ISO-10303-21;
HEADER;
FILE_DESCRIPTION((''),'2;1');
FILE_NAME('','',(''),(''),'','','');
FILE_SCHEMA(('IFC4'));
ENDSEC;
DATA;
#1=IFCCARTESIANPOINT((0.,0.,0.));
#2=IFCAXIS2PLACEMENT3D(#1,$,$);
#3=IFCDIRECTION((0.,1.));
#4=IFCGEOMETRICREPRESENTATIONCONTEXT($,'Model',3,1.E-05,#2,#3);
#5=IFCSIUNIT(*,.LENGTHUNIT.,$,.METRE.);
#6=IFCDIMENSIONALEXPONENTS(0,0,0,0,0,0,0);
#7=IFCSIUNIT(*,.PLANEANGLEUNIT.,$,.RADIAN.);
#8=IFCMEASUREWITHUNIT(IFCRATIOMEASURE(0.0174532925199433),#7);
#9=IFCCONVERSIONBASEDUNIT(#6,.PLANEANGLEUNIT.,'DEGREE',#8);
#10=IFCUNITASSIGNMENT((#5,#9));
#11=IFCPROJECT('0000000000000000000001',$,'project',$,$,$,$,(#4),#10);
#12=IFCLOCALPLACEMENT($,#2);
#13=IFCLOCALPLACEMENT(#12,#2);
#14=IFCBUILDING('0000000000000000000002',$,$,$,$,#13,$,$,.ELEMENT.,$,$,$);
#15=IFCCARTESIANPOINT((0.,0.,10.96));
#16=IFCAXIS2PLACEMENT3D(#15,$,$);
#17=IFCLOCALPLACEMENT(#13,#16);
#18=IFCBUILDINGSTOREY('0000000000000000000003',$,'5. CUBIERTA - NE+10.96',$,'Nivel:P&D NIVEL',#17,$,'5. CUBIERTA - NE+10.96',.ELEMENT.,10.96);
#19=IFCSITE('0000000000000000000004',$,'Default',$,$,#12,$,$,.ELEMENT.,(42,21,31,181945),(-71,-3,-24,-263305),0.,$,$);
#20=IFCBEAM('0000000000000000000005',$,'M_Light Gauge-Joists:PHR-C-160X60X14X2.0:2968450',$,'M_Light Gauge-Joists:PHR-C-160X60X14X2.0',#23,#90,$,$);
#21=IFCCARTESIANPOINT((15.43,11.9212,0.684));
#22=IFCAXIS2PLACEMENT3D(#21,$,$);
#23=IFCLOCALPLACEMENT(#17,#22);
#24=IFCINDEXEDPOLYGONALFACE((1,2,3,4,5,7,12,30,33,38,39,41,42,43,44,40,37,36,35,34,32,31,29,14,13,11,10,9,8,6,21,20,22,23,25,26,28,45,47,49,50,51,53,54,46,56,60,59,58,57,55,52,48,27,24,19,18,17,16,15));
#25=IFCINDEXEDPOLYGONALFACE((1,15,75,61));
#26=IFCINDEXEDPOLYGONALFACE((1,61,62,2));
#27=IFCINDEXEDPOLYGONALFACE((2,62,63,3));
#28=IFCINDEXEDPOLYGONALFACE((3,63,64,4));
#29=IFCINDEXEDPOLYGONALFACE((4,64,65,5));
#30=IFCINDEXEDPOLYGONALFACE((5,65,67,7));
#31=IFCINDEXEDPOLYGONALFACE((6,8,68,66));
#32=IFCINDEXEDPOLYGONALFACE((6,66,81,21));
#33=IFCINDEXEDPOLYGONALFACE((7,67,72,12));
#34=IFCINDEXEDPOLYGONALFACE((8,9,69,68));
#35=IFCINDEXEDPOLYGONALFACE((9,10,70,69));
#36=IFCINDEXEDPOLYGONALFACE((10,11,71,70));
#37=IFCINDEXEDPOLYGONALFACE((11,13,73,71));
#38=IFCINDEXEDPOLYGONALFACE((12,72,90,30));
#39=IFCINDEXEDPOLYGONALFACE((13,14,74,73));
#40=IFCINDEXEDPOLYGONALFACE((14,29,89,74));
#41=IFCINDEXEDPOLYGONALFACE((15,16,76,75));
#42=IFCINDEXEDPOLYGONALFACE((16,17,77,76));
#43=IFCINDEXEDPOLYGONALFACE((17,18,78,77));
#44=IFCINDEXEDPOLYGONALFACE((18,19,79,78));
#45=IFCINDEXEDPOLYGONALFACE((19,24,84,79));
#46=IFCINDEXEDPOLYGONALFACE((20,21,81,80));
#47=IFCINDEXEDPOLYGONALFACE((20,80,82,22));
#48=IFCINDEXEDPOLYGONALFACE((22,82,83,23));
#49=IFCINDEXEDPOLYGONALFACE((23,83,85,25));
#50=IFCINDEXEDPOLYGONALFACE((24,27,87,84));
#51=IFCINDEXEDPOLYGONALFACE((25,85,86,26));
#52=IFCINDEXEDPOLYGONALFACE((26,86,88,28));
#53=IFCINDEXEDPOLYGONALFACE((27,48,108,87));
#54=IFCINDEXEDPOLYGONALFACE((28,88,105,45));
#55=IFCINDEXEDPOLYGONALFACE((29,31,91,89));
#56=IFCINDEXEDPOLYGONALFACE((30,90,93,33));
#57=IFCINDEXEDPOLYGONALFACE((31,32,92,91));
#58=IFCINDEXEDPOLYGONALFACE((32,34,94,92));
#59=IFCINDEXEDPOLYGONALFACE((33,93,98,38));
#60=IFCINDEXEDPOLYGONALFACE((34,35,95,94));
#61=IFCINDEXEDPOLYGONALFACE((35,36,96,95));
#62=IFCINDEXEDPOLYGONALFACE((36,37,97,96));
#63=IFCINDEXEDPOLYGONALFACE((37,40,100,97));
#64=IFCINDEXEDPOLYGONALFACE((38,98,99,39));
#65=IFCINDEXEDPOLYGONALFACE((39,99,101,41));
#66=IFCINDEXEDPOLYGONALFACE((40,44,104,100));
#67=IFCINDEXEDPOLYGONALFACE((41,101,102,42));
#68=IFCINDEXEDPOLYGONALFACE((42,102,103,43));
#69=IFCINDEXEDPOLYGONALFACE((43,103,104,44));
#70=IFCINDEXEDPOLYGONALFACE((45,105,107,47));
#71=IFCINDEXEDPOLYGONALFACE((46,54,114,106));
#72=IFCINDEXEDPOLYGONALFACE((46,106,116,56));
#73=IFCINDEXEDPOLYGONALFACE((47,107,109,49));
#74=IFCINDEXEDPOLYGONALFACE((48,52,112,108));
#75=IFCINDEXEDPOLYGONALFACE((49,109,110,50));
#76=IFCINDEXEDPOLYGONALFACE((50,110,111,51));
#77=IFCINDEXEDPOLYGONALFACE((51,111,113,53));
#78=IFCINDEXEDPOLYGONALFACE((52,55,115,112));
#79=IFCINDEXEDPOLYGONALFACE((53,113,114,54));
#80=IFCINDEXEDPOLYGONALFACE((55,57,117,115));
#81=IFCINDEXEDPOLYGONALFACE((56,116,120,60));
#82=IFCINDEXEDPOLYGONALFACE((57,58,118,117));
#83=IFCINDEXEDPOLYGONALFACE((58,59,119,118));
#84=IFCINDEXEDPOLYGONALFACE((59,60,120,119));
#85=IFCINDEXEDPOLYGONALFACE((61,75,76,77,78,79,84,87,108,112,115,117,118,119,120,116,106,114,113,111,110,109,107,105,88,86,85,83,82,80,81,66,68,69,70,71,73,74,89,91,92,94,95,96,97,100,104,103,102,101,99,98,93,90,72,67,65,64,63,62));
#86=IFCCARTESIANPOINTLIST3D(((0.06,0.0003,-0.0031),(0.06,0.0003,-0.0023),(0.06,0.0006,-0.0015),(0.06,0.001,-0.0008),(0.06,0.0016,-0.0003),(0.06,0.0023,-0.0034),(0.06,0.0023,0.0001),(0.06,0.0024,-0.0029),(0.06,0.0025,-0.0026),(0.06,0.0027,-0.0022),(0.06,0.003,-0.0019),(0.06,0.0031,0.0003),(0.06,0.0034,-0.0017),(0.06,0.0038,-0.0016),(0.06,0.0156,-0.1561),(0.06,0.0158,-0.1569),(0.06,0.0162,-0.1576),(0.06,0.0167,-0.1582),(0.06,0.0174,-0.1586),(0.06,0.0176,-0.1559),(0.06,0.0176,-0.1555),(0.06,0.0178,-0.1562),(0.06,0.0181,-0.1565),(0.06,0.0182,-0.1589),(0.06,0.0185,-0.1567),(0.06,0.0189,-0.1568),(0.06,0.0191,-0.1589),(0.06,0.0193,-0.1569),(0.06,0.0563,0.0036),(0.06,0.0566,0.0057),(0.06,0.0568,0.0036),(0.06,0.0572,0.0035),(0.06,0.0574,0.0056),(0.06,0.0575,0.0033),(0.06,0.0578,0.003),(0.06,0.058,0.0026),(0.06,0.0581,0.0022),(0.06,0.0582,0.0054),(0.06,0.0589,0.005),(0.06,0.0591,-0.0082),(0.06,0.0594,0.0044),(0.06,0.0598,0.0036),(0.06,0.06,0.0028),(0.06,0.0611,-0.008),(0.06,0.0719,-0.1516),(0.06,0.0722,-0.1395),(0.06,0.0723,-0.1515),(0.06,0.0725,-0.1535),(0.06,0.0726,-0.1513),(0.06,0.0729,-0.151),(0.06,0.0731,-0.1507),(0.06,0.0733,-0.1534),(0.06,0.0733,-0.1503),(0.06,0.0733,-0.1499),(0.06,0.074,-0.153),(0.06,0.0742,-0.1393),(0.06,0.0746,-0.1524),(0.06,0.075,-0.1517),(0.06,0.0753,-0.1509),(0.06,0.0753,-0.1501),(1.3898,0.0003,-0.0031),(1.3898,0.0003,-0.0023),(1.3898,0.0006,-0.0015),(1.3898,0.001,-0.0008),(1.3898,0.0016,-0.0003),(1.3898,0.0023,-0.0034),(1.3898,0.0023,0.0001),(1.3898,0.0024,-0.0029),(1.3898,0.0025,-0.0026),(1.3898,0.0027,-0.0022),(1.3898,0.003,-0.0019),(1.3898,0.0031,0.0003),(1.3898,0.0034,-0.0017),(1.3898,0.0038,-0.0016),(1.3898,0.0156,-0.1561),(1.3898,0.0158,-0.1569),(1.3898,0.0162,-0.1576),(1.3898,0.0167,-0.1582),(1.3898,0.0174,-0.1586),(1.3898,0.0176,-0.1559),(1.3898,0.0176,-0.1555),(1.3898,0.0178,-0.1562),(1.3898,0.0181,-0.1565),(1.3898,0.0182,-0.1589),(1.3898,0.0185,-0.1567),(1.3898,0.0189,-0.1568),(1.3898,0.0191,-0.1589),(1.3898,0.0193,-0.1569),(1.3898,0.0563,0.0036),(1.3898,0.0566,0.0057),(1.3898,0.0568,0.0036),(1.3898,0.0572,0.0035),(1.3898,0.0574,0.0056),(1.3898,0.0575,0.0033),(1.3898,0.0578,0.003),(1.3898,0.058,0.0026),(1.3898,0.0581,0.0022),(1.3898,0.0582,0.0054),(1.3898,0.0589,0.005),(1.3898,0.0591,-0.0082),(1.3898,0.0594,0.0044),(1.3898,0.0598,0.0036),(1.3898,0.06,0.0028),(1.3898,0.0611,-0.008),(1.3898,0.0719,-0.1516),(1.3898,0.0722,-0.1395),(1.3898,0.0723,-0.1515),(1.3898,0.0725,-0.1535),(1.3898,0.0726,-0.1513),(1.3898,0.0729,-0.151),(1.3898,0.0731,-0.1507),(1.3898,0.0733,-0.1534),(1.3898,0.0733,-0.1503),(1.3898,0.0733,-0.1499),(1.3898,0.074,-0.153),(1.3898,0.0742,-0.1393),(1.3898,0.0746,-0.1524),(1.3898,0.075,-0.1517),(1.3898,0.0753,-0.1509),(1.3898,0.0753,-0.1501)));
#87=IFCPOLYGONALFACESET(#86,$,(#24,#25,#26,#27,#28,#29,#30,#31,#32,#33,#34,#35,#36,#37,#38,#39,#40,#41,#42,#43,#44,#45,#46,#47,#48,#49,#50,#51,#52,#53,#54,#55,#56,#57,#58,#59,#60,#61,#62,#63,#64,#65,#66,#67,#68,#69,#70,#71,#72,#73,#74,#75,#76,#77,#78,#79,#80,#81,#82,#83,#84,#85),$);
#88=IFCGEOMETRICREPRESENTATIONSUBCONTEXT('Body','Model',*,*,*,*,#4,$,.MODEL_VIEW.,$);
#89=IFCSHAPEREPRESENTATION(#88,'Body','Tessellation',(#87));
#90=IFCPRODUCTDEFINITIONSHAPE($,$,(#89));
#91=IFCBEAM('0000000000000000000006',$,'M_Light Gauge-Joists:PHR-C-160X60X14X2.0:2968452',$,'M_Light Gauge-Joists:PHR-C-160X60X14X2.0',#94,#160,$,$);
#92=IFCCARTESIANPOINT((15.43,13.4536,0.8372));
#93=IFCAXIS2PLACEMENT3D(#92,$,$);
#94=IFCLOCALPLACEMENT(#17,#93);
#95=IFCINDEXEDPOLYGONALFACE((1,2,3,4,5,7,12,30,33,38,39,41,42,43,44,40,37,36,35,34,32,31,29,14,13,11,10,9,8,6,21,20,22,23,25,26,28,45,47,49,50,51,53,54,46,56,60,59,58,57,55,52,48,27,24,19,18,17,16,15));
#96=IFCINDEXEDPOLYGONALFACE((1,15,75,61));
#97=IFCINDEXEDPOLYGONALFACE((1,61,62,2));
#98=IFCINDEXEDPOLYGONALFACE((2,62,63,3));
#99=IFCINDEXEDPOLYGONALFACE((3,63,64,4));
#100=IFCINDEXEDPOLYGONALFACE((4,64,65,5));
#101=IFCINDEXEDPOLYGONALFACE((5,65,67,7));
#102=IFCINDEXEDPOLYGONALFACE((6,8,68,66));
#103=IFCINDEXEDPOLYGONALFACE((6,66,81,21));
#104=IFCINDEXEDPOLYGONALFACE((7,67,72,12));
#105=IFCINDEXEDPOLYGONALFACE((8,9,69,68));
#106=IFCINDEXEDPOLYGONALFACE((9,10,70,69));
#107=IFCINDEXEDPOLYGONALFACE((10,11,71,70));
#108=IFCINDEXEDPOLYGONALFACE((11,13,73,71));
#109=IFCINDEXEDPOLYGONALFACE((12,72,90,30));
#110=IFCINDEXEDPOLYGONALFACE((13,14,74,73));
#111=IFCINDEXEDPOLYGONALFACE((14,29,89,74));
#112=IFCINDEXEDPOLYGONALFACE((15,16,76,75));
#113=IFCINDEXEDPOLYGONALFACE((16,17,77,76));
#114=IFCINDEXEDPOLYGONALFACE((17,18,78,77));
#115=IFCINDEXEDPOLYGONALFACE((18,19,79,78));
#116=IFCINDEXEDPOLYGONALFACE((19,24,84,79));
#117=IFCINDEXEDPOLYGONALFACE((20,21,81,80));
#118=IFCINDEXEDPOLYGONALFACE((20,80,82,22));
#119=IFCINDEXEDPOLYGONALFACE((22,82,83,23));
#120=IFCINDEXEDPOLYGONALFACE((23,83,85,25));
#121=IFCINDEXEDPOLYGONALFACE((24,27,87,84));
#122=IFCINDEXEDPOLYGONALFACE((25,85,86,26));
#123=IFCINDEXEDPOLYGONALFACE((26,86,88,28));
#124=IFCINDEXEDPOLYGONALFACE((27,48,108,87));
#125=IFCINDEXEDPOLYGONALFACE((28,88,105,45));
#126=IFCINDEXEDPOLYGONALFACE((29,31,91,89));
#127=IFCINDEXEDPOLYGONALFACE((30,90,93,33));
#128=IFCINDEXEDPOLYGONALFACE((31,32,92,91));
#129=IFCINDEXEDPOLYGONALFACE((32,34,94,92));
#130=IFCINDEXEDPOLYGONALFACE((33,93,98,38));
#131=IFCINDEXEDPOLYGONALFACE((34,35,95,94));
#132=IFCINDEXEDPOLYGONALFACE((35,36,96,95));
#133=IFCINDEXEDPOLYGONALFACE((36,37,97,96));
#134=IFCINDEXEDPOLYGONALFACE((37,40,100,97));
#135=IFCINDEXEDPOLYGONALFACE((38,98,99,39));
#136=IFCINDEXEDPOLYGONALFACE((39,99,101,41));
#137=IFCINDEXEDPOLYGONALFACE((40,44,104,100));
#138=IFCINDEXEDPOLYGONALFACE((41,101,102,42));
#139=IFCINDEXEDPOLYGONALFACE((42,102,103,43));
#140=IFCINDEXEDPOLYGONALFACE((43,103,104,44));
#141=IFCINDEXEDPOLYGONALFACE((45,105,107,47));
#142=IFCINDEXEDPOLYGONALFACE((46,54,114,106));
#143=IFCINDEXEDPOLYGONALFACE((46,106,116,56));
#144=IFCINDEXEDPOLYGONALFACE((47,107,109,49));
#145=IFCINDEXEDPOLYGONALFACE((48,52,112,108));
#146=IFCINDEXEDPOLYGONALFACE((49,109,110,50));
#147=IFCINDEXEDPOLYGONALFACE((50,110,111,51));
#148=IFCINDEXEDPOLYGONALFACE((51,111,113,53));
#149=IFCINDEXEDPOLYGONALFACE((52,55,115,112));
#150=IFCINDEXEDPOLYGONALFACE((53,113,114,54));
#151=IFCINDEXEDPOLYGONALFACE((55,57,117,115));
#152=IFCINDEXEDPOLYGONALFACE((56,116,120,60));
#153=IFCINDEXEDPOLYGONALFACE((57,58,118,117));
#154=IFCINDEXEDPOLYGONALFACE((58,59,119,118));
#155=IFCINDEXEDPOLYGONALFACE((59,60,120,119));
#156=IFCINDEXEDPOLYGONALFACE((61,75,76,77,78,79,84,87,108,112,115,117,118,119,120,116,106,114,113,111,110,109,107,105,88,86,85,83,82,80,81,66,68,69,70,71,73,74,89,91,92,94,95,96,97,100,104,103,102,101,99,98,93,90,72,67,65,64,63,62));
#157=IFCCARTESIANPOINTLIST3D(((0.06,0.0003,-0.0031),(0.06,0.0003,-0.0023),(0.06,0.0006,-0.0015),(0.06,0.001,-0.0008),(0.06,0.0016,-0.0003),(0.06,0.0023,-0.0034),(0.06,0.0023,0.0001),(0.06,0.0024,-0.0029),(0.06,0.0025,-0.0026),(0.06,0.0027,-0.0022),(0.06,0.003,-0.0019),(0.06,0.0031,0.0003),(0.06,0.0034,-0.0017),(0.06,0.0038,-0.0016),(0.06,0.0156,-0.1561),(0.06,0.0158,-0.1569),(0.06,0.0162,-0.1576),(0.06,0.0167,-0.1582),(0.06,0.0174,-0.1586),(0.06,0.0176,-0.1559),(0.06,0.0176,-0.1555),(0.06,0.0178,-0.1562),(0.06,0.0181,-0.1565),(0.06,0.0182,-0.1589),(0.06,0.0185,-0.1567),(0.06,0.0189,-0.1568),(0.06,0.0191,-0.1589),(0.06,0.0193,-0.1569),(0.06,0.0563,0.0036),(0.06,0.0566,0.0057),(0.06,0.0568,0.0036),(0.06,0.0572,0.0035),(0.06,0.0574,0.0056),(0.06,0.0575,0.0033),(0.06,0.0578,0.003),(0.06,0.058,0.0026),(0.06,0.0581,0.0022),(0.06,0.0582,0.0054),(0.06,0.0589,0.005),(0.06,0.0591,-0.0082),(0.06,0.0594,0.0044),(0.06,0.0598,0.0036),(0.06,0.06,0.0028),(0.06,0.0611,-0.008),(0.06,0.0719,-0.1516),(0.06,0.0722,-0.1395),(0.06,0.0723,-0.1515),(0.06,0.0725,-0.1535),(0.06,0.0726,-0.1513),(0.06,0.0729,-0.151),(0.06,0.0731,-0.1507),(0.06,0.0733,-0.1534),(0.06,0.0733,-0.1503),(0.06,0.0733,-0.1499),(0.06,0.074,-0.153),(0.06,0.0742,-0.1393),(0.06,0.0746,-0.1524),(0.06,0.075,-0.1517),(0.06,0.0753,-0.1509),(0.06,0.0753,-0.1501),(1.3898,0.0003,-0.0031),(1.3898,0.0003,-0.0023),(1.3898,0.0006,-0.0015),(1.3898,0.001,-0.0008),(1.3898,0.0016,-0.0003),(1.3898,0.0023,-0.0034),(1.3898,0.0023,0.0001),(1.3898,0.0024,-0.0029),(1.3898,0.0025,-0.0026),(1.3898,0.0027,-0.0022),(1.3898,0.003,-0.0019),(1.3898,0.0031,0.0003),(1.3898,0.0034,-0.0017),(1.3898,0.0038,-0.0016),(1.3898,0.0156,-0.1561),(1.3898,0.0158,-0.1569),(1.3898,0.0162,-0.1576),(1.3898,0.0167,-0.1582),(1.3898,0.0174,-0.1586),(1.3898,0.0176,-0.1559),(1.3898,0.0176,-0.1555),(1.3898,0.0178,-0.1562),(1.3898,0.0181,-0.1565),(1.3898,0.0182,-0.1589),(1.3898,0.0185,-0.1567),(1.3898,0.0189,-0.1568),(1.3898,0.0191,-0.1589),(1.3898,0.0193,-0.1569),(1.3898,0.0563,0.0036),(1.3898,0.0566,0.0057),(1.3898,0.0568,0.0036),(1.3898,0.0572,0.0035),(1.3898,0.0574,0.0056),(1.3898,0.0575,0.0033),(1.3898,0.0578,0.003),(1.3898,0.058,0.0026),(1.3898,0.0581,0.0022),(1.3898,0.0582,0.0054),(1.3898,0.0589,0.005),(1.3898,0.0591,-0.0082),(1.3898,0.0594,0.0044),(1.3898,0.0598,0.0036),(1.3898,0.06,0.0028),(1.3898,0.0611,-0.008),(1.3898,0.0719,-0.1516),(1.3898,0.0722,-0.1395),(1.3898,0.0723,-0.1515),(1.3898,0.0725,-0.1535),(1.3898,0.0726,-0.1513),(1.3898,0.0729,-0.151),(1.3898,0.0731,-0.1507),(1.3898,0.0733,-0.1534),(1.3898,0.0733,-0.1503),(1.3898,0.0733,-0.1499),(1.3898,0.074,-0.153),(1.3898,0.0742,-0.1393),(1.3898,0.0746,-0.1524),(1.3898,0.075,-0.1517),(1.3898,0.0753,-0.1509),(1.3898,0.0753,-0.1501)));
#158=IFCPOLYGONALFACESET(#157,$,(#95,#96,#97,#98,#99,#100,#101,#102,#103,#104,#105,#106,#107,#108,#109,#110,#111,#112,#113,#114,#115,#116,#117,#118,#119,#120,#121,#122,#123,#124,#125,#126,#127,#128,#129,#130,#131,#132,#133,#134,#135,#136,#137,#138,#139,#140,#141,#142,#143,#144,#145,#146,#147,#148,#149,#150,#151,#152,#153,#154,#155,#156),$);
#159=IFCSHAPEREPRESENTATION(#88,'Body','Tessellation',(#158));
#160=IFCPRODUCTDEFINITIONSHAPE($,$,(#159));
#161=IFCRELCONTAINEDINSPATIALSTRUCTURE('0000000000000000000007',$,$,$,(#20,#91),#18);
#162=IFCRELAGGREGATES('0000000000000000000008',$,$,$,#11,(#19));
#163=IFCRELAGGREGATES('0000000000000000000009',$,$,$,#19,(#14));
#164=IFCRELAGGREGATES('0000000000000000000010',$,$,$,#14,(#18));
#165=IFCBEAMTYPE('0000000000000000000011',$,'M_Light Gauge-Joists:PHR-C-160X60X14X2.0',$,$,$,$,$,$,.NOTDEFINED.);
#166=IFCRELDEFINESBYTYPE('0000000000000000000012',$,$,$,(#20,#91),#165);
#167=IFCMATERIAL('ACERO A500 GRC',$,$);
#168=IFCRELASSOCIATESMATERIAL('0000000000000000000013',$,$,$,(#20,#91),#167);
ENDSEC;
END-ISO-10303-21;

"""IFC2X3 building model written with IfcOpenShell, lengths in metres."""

from ifc_helpers import new_model, entity, si_unit, converted_unit, direction, frame, frame_2d, origin, place, context, subcontext, project, spatial, polyline, circle_curve, parameter, trimmed, segment, composite_curve, outline, extrude, material, type_object, element, save


model = new_model("IFC2X3")

# Units and contexts
model_context = context("Model", 3, precision=1e-05, world=origin(), true_north=direction((0.0, 1.0)))
body_context = subcontext(model_context, "Body", "Model", "MODEL_VIEW")
ifc_project = project(units=[si_unit("LENGTHUNIT", "METRE"), converted_unit("PLANEANGLEUNIT", "DEGREE", entity("IfcRatioMeasure", 0.0174532925199433), si_unit("PLANEANGLEUNIT", "RADIAN"), dimensions=[0, 0, 0, 0, 0, 0, 0])], contexts=[model_context])

# Site, building, storey
site_placement = place(None, origin())
site = spatial("IfcSite", under=ifc_project, at=site_placement, Name="Default", CompositionType="ELEMENT", RefLatitude=(42, 21, 31, 181945), RefLongitude=(-71, -3, -24, -263305), RefElevation=0.0)
building_placement = place(site_placement, origin())
building = spatial("IfcBuilding", under=site, at=building_placement, CompositionType="ELEMENT")
storey_placement = place(building_placement, frame((0.0, 0.0, 10.96)))
storey = spatial("IfcBuildingStorey", under=building, at=storey_placement, Name="5. CUBIERTA - NE+10.96", ObjectType="Nivel:P&D NIVEL", LongName="5. CUBIERTA - NE+10.96", CompositionType="ELEMENT", Elevation=10.96)

# Beams
ifc_material_1 = material(Name="ACERO A500 GRC")
beam_type_1 = type_object("IfcBeamType", Name="M_Light Gauge-Joists:PHR-C-160X60X14X2.0", PredefinedType="NOTDEFINED")
beam_1_placement = place(storey_placement, frame((15.43, 11.9212, 0.684)))
element("IfcBeam", 1, at=beam_1_placement, inside=storey, type_object=beam_type_1, material=ifc_material_1, Name="M_Light Gauge-Joists:PHR-C-160X60X14X2.0:2968450", ObjectType="M_Light Gauge-Joists:PHR-C-160X60X14X2.0", context=body_context, shape_type="SweptSolid", body=[
    extrude(outline(composite_curve([segment(trimmed(circle_curve(frame_2d((-0.0764, -0.0322), x_axis=(-1.0, 0.0)), 0.0016), [parameter(0.0)], [parameter(90.0)], True, "PARAMETER"), False, "CONTINUOUS"), segment(polyline([(-0.078, -0.0322), (-0.078, 0.0206)]), True, "CONTINUOUS"), segment(trimmed(circle_curve(frame_2d((-0.0764, 0.0206), x_axis=(0.0, 1.0)), 0.0016), [parameter(0.0)], [parameter(90.0)], True, "PARAMETER"), False, "CONTINUOUS"), segment(polyline([(-0.0764, 0.0222), (-0.066, 0.0222)]), True, "CONTINUOUS"), segment(polyline([(-0.066, 0.0222), (-0.066, 0.0242)]), True, "CONTINUOUS"), segment(polyline([(-0.066, 0.0242), (-0.0768, 0.0242)]), True, "CONTINUOUS"), segment(trimmed(circle_curve(frame_2d((-0.0768, 0.021), x_axis=(-1.0, 0.0)), 0.0032), [parameter(270.0)], [parameter(0.0)], True, "PARAMETER"), True, "CONTINUOUS"), segment(polyline([(-0.08, 0.021), (-0.08, -0.0326)]), True, "CONTINUOUS"), segment(trimmed(circle_curve(frame_2d((-0.0768, -0.0326), x_axis=(0.0, -1.0)), 0.0032), [parameter(270.0)], [parameter(0.0)], True, "PARAMETER"), True, "CONTINUOUS"), segment(polyline([(-0.0768, -0.0358), (0.0768, -0.0358)]), True, "CONTINUOUS"), segment(trimmed(circle_curve(frame_2d((0.0768, -0.0326), x_axis=(1.0, 0.0)), 0.0032), [parameter(270.0)], [parameter(0.0)], True, "PARAMETER"), True, "CONTINUOUS"), segment(polyline([(0.08, -0.0326), (0.08, 0.021)]), True, "CONTINUOUS"), segment(trimmed(circle_curve(frame_2d((0.0768, 0.021), x_axis=(0.0, 1.0)), 0.0032), [parameter(270.0)], [parameter(0.0)], True, "PARAMETER"), True, "CONTINUOUS"), segment(polyline([(0.0768, 0.0242), (0.066, 0.0242)]), True, "CONTINUOUS"), segment(polyline([(0.066, 0.0242), (0.066, 0.0222)]), True, "CONTINUOUS"), segment(polyline([(0.066, 0.0222), (0.0764, 0.0222)]), True, "CONTINUOUS"), segment(trimmed(circle_curve(frame_2d((0.0764, 0.0206), x_axis=(1.0, 0.0)), 0.0016), [parameter(0.0)], [parameter(90.0)], True, "PARAMETER"), False, "CONTINUOUS"), segment(polyline([(0.078, 0.0206), (0.078, -0.0322)]), True, "CONTINUOUS"), segment(trimmed(circle_curve(frame_2d((0.0764, -0.0322), x_axis=(0.0, -1.0)), 0.0016), [parameter(0.0)], [parameter(90.0)], True, "PARAMETER"), False, "CONTINUOUS"), segment(polyline([(0.0764, -0.0338), (-0.0764, -0.0338)]), True, "CONTINUOUS")], self_intersect=False)), frame((0.06, 0.0436, -0.076), z_axis=(-1.0, 0.0, 0.0), x_axis=(0.0, -0.099504, 0.995037)), (0.0, 0.0, -1.0), 1.3298),
])
beam_2_placement = place(storey_placement, frame((15.43, 13.4536, 0.8372)))
element("IfcBeam", 2, at=beam_2_placement, inside=storey, type_object=beam_type_1, material=ifc_material_1, Name="M_Light Gauge-Joists:PHR-C-160X60X14X2.0:2968452", ObjectType="M_Light Gauge-Joists:PHR-C-160X60X14X2.0", context=body_context, shape_type="SweptSolid", body=[
    extrude(outline(composite_curve([segment(trimmed(circle_curve(frame_2d((-0.0764, -0.0322), x_axis=(-1.0, 0.0)), 0.0016), [parameter(0.0)], [parameter(90.0)], True, "PARAMETER"), False, "CONTINUOUS"), segment(polyline([(-0.078, -0.0322), (-0.078, 0.0206)]), True, "CONTINUOUS"), segment(trimmed(circle_curve(frame_2d((-0.0764, 0.0206), x_axis=(0.0, 1.0)), 0.0016), [parameter(0.0)], [parameter(90.0)], True, "PARAMETER"), False, "CONTINUOUS"), segment(polyline([(-0.0764, 0.0222), (-0.066, 0.0222)]), True, "CONTINUOUS"), segment(polyline([(-0.066, 0.0222), (-0.066, 0.0242)]), True, "CONTINUOUS"), segment(polyline([(-0.066, 0.0242), (-0.0768, 0.0242)]), True, "CONTINUOUS"), segment(trimmed(circle_curve(frame_2d((-0.0768, 0.021), x_axis=(-1.0, 0.0)), 0.0032), [parameter(270.0)], [parameter(0.0)], True, "PARAMETER"), True, "CONTINUOUS"), segment(polyline([(-0.08, 0.021), (-0.08, -0.0326)]), True, "CONTINUOUS"), segment(trimmed(circle_curve(frame_2d((-0.0768, -0.0326), x_axis=(0.0, -1.0)), 0.0032), [parameter(270.0)], [parameter(0.0)], True, "PARAMETER"), True, "CONTINUOUS"), segment(polyline([(-0.0768, -0.0358), (0.0768, -0.0358)]), True, "CONTINUOUS"), segment(trimmed(circle_curve(frame_2d((0.0768, -0.0326), x_axis=(1.0, 0.0)), 0.0032), [parameter(270.0)], [parameter(0.0)], True, "PARAMETER"), True, "CONTINUOUS"), segment(polyline([(0.08, -0.0326), (0.08, 0.021)]), True, "CONTINUOUS"), segment(trimmed(circle_curve(frame_2d((0.0768, 0.021), x_axis=(0.0, 1.0)), 0.0032), [parameter(270.0)], [parameter(0.0)], True, "PARAMETER"), True, "CONTINUOUS"), segment(polyline([(0.0768, 0.0242), (0.066, 0.0242)]), True, "CONTINUOUS"), segment(polyline([(0.066, 0.0242), (0.066, 0.0222)]), True, "CONTINUOUS"), segment(polyline([(0.066, 0.0222), (0.0764, 0.0222)]), True, "CONTINUOUS"), segment(trimmed(circle_curve(frame_2d((0.0764, 0.0206), x_axis=(1.0, 0.0)), 0.0016), [parameter(0.0)], [parameter(90.0)], True, "PARAMETER"), False, "CONTINUOUS"), segment(polyline([(0.078, 0.0206), (0.078, -0.0322)]), True, "CONTINUOUS"), segment(trimmed(circle_curve(frame_2d((0.0764, -0.0322), x_axis=(0.0, -1.0)), 0.0016), [parameter(0.0)], [parameter(90.0)], True, "PARAMETER"), False, "CONTINUOUS"), segment(polyline([(0.0764, -0.0338), (-0.0764, -0.0338)]), True, "CONTINUOUS")], self_intersect=False)), frame((0.06, 0.0436, -0.076), z_axis=(-1.0, 0.0, 0.0), x_axis=(0.0, -0.099504, 0.995037)), (0.0, 0.0, -1.0), 1.3298),
])

save(model, "model.ifc")
